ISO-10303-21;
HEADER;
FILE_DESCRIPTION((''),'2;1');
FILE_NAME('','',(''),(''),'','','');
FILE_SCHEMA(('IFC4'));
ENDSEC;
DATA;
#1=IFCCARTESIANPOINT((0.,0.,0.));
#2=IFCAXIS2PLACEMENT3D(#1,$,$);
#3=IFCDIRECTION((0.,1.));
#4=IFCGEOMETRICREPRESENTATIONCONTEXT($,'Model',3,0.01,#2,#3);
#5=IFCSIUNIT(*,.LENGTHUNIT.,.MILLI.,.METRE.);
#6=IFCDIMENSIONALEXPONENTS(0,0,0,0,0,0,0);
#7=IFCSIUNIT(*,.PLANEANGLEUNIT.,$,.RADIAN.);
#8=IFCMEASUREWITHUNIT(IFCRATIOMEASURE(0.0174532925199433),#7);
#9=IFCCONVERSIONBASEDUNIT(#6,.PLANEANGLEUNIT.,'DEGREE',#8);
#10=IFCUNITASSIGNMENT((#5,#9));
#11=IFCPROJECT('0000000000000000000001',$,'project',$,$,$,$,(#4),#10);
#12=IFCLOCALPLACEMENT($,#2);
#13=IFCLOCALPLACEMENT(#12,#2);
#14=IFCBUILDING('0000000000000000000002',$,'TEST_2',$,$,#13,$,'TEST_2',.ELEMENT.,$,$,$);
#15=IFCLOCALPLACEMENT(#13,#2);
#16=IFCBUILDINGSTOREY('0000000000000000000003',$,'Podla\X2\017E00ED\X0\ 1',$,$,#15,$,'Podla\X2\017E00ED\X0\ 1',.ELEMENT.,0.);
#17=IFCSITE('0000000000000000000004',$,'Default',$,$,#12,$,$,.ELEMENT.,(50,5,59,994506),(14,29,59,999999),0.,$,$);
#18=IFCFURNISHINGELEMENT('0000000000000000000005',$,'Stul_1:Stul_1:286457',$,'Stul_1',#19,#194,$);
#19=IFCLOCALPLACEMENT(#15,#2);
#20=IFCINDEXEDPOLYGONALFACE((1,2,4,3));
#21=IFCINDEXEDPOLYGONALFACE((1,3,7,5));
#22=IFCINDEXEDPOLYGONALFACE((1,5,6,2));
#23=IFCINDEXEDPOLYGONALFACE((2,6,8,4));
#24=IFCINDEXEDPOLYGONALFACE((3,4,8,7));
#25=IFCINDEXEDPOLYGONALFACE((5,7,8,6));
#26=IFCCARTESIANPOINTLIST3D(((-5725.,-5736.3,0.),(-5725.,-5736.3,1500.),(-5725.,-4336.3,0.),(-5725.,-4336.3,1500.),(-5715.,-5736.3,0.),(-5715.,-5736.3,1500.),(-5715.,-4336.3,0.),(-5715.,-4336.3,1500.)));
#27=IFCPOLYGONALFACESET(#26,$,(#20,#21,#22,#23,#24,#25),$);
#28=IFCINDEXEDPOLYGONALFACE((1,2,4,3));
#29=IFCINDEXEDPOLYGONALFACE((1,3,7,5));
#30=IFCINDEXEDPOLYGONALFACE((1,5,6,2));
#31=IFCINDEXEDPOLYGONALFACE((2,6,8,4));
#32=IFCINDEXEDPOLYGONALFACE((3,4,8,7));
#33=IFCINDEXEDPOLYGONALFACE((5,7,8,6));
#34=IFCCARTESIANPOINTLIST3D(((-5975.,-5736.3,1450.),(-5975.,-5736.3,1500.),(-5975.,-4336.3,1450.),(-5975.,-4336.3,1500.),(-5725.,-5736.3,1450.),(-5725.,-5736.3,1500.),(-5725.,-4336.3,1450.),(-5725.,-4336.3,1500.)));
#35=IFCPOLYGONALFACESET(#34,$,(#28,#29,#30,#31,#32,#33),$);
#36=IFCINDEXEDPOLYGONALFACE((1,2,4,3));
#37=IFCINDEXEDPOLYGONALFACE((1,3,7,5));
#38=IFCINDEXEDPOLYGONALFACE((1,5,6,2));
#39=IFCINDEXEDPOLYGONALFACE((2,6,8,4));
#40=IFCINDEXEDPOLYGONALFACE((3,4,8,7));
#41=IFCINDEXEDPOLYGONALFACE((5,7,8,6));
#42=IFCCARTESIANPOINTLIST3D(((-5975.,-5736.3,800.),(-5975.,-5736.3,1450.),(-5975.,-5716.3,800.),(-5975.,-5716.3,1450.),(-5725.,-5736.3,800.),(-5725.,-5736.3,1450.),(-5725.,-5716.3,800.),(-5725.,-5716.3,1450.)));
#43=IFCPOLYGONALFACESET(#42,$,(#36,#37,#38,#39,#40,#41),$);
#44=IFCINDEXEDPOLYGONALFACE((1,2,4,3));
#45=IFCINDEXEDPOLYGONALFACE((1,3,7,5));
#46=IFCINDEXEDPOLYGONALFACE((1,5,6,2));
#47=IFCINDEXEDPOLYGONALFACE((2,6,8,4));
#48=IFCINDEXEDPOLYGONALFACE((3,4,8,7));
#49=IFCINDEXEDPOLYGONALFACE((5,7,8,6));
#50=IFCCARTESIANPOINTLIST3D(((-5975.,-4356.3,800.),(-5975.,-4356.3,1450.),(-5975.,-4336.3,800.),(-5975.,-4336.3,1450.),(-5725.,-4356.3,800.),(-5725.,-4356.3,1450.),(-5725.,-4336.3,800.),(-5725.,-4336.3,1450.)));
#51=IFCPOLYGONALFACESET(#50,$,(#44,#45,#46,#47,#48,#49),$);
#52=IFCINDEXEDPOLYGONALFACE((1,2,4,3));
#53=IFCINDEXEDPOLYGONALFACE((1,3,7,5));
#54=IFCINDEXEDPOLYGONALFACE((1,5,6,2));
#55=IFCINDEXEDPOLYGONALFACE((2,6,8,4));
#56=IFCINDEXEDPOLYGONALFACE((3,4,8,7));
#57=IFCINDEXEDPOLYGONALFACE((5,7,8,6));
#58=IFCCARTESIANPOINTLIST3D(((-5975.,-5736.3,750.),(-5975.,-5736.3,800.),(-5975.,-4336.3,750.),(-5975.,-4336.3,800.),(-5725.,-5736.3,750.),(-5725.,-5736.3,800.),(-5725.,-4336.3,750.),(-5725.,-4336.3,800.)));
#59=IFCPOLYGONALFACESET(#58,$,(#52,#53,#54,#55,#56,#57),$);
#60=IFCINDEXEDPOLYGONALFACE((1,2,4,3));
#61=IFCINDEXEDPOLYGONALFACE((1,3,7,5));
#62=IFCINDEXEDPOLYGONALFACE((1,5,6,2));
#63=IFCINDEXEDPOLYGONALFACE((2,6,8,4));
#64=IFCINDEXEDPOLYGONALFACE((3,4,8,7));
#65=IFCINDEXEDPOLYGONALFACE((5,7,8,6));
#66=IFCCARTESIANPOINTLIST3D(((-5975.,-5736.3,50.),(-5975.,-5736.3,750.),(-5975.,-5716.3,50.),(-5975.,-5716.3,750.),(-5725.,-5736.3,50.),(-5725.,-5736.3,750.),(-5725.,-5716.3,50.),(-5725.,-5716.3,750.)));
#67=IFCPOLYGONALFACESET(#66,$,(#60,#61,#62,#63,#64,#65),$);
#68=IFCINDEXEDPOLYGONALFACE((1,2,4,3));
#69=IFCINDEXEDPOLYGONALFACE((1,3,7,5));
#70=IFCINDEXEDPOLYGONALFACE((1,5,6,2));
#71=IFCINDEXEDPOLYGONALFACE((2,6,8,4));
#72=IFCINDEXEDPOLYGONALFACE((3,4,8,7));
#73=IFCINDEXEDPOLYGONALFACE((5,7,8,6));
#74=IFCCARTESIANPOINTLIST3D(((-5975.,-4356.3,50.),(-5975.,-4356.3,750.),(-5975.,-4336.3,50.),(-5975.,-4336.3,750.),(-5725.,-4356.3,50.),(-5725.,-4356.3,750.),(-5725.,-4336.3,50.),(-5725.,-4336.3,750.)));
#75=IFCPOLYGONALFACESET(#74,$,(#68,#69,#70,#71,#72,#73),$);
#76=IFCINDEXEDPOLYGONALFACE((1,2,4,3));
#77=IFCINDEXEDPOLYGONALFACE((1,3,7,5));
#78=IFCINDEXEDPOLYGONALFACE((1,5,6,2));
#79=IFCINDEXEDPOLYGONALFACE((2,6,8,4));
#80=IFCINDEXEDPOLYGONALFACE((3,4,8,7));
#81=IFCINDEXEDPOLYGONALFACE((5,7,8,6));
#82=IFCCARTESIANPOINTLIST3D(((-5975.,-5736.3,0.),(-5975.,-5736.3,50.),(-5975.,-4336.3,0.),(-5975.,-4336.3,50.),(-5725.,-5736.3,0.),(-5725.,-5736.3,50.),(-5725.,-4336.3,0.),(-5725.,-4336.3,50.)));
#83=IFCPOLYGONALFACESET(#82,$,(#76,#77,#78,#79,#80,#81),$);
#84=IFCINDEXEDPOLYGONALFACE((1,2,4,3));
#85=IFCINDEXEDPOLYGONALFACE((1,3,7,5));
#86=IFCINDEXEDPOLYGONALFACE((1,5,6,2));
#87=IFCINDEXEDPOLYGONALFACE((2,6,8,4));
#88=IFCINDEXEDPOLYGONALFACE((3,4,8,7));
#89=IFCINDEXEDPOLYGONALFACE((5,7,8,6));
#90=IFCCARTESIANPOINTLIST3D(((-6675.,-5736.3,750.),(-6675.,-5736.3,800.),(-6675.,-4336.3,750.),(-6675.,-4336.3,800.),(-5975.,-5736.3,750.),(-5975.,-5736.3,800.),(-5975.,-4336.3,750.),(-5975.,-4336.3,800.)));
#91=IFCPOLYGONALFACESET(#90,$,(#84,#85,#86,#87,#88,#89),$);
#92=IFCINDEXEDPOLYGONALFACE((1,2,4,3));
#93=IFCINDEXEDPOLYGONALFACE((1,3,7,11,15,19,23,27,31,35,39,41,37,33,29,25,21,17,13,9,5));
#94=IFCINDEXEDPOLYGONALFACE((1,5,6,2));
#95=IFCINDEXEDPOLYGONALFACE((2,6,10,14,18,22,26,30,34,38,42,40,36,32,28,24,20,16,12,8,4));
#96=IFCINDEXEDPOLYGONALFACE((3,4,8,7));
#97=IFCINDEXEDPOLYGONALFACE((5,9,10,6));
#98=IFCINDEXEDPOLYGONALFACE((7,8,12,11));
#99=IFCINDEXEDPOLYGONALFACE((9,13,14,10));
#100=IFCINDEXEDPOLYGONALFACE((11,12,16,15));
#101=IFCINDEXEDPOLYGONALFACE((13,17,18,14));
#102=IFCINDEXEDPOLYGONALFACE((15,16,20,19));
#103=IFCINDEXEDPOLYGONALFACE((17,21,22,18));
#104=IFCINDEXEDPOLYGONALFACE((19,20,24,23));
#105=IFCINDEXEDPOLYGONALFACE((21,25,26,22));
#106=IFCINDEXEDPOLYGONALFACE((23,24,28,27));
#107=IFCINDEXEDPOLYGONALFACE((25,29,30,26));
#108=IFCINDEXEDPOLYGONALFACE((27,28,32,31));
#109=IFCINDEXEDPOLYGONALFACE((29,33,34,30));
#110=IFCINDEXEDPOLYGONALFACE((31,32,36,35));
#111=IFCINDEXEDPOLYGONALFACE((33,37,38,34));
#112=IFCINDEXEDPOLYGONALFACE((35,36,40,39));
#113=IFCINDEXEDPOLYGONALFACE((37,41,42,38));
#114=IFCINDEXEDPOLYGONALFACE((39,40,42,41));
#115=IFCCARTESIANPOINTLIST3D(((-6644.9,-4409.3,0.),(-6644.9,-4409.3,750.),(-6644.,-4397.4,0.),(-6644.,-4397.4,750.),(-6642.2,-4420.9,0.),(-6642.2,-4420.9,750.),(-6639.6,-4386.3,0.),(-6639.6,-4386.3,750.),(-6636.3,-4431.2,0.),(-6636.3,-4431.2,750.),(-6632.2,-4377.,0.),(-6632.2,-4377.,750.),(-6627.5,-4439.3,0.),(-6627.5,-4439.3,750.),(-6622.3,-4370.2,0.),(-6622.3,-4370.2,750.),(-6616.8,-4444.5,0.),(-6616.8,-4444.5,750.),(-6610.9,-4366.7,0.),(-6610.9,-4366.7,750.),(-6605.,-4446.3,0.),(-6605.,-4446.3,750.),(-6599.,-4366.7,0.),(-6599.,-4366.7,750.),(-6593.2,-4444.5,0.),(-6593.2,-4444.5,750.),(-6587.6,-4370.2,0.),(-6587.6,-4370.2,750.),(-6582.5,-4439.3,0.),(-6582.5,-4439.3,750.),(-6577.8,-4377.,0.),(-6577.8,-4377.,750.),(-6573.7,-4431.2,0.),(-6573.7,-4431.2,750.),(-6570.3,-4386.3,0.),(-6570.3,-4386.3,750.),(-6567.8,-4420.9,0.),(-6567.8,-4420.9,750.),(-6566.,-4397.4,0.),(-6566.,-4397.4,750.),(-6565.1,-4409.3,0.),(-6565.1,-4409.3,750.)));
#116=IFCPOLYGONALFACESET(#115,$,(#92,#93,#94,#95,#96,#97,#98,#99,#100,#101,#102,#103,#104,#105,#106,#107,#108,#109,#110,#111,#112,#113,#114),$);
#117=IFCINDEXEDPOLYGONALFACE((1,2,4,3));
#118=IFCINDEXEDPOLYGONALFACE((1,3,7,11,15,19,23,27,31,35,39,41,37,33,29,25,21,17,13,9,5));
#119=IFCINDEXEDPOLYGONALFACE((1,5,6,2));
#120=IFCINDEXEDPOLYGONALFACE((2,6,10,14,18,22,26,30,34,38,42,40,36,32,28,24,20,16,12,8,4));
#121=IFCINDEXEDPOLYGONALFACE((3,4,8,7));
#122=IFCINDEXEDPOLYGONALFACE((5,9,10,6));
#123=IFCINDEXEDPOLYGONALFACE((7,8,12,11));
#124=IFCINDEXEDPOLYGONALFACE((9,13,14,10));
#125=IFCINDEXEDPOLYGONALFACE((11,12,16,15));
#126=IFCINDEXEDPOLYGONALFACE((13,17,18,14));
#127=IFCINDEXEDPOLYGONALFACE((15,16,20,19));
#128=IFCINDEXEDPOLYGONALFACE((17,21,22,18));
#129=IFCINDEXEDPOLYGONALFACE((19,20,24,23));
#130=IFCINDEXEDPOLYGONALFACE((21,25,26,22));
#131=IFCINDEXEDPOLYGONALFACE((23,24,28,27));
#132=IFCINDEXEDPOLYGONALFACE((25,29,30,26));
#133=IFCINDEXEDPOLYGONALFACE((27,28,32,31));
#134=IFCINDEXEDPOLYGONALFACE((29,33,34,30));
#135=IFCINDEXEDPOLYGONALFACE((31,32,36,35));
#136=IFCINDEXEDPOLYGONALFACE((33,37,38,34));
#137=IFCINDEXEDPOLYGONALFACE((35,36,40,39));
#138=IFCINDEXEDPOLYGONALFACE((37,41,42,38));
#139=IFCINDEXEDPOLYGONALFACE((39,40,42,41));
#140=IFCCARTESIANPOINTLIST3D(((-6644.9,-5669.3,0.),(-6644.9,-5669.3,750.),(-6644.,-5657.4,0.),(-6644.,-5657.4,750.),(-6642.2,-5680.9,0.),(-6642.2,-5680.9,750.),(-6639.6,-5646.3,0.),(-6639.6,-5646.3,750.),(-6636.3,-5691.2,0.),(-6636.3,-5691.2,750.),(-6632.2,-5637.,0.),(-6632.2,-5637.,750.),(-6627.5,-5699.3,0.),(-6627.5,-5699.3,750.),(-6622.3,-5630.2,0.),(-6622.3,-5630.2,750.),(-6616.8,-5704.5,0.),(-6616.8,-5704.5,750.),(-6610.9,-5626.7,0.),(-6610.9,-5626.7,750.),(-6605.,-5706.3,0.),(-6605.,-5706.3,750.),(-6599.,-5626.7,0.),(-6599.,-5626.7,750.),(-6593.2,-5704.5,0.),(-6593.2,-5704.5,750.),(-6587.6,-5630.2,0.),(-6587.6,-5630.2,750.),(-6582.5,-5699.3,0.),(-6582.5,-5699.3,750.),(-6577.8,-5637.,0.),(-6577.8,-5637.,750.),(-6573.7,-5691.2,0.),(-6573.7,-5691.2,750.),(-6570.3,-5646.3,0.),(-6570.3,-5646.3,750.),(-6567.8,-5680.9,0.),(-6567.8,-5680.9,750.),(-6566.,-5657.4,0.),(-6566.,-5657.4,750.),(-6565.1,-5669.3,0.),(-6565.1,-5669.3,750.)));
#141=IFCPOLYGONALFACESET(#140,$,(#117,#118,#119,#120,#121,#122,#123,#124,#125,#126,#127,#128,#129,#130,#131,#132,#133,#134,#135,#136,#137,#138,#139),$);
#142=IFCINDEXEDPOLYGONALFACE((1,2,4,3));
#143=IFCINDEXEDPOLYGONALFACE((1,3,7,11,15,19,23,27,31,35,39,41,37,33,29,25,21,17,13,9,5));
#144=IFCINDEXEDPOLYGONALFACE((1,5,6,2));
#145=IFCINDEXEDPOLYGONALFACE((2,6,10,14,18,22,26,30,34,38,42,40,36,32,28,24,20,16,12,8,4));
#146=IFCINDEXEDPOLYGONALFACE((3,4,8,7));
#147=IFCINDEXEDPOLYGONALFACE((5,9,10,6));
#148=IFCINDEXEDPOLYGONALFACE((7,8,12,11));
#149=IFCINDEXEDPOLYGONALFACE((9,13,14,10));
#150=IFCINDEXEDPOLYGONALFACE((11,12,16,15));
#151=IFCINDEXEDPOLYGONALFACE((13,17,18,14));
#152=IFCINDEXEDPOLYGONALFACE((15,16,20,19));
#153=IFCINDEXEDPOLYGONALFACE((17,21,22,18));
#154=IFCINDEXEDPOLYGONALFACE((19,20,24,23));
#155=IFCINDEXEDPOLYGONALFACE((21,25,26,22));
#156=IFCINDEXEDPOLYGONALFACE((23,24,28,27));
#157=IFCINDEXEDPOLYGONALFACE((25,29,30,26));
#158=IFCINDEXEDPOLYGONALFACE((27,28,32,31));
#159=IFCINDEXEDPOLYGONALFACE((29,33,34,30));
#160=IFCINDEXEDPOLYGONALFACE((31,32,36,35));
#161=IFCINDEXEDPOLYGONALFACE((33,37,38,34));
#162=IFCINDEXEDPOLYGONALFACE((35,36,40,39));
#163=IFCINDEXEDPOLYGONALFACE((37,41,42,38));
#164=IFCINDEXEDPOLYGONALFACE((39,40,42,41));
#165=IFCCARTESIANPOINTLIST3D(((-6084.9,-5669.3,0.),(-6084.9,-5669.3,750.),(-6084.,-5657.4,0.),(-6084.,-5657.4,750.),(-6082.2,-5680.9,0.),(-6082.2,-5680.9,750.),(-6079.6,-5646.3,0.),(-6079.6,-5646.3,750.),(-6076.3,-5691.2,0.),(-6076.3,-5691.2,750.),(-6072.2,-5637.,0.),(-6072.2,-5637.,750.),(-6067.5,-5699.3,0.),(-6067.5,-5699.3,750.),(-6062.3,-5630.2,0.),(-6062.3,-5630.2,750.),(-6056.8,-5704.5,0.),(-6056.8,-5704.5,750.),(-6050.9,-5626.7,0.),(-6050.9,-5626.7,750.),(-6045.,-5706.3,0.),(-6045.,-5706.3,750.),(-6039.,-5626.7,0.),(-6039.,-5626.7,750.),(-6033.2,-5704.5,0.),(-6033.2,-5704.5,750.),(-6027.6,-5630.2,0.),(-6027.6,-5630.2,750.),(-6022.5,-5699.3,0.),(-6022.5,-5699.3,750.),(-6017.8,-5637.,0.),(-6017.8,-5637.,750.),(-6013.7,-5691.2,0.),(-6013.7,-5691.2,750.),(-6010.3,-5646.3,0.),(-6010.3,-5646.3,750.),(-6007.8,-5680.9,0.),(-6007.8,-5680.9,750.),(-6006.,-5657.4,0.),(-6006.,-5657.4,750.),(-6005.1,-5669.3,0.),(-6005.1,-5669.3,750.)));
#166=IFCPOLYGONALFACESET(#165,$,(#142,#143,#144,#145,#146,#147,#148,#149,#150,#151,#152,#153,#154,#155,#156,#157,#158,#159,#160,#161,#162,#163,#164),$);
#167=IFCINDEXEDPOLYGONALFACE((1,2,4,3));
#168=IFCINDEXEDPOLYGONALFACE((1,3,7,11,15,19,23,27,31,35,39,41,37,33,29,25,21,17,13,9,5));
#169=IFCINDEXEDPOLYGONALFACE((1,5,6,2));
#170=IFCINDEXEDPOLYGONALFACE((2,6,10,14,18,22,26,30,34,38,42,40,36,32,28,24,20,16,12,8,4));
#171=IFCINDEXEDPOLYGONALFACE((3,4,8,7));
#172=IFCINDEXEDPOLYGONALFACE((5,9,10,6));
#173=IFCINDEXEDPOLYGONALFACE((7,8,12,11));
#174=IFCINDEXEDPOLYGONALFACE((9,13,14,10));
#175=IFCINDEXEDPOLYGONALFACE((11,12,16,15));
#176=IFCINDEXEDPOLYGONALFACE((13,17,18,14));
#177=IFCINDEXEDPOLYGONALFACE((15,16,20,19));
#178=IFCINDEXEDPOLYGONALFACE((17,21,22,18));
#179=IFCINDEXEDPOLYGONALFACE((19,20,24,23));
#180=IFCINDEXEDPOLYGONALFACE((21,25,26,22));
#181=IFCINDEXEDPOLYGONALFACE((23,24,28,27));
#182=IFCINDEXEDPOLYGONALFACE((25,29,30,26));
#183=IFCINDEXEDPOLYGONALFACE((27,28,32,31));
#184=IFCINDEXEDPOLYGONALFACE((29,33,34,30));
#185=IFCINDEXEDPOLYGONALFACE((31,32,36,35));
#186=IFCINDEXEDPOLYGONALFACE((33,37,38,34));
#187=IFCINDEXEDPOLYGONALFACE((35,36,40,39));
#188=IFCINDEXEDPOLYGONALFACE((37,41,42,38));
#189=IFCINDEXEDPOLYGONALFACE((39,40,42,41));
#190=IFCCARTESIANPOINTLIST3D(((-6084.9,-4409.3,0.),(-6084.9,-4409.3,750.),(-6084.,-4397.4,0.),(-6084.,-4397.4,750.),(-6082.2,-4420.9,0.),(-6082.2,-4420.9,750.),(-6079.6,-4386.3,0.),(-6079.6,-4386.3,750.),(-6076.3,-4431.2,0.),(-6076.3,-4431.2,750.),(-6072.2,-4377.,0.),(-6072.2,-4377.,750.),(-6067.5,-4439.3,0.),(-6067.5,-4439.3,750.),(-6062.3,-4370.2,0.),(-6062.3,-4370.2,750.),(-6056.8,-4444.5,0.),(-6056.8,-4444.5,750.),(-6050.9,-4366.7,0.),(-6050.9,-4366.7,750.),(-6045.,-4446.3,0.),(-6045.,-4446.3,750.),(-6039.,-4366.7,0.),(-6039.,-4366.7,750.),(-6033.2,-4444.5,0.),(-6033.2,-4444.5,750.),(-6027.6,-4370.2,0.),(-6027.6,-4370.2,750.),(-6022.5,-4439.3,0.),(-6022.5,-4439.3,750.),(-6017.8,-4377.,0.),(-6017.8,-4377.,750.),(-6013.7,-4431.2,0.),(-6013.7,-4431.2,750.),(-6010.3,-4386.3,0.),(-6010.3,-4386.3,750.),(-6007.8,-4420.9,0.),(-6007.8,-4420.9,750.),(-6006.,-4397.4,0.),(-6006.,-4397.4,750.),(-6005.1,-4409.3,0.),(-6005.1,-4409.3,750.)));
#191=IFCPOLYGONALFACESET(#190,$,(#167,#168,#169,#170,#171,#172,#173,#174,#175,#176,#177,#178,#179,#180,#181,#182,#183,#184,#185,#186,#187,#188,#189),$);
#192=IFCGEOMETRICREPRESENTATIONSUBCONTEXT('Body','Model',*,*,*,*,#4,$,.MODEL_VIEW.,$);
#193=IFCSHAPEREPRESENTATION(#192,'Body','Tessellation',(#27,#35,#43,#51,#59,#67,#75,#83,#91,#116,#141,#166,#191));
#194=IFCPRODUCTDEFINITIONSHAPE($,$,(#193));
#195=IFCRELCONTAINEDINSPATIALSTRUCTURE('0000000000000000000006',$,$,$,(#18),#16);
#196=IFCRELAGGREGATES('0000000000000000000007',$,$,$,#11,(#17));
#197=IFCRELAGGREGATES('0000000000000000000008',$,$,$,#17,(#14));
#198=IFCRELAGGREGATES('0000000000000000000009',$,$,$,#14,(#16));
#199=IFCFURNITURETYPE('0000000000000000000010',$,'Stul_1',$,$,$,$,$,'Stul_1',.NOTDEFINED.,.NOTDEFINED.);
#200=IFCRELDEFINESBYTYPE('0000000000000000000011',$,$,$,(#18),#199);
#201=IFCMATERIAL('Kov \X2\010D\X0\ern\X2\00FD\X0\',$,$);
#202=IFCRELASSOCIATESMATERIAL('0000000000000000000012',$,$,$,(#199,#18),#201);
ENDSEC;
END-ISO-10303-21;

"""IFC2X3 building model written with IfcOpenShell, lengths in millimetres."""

from ifc_helpers import new_model, entity, si_unit, converted_unit, direction, frame, frame_2d, origin, origin_2d_with_axis, place, context, subcontext, project, spatial, rectangle, circle, extrude, source, transform, mapped, material, type_object, type_shapes, element, save


model = new_model("IFC2X3")

# Units and contexts
model_context = context("Model", 3, precision=0.01, world=origin(), true_north=direction((0.0, 1.0)))
body_context = subcontext(model_context, "Body", "Model", "MODEL_VIEW")
ifc_project = project(units=[si_unit("LENGTHUNIT", "METRE", prefix="MILLI"), converted_unit("PLANEANGLEUNIT", "DEGREE", entity("IfcRatioMeasure", 0.0174532925199433), si_unit("PLANEANGLEUNIT", "RADIAN"), dimensions=[0, 0, 0, 0, 0, 0, 0])], contexts=[model_context])

# Site, building, storey
site_placement = place(None, origin())
site = spatial("IfcSite", under=ifc_project, at=site_placement, Name="Default", CompositionType="ELEMENT", RefLatitude=(50, 5, 59, 994506), RefLongitude=(14, 29, 59, 999999), RefElevation=0.0)
building_placement = place(site_placement, origin())
building = spatial("IfcBuilding", under=site, at=building_placement, Name="TEST_2", LongName="TEST_2", CompositionType="ELEMENT")
storey_placement = place(building_placement, origin())
storey = spatial("IfcBuildingStorey", under=building, at=storey_placement, Name="Podlaží 1", LongName="Podlaží 1", CompositionType="ELEMENT", Elevation=0.0)

# Furnishing element
ifc_material = material(Name="Kov černý")
furniture_type = type_object("IfcFurnitureType", Name="Stul_1", ElementType="Stul_1", material=ifc_material)
shared_shape = source(origin(), body_context, "Body", "SweptSolid", [
    extrude(rectangle(XDim=1400.0, YDim=10.0, at=origin_2d_with_axis()), frame((0.0, 605.0, 0.0), z_axis=(0.0, 0.0, 1.0), x_axis=(-1.0, 0.0, 0.0)), (0.0, 0.0, 1.0), 1500.0),
    extrude(rectangle(XDim=1400.0, YDim=250.0, at=frame_2d((0.0, 0.0), x_axis=(1.0, 0.0))), frame((0.0, 475.0, 1450.0), z_axis=(0.0, 0.0, 1.0), x_axis=(-1.0, 0.0, 0.0)), (0.0, 0.0, 1.0), 50.0),
    extrude(rectangle(XDim=20.0, YDim=250.0, at=origin_2d_with_axis()), frame((690.0, 475.0, 800.0), z_axis=(0.0, 0.0, 1.0), x_axis=(-1.0, 0.0, 0.0)), (0.0, 0.0, 1.0), 650.0),
    extrude(rectangle(XDim=20.0, YDim=250.0, at=frame_2d((0.0, 0.0), x_axis=(1.0, 0.0))), frame((-690.0, 475.0, 800.0), z_axis=(0.0, 0.0, 1.0), x_axis=(-1.0, 0.0, 0.0)), (0.0, 0.0, 1.0), 650.0),
    extrude(rectangle(XDim=1400.0, YDim=250.0, at=origin_2d_with_axis()), frame((0.0, 475.0, 750.0), z_axis=(0.0, 0.0, 1.0), x_axis=(-1.0, 0.0, 0.0)), (0.0, 0.0, 1.0), 50.0),
    extrude(rectangle(XDim=20.0, YDim=250.0, at=origin_2d_with_axis()), frame((690.0, 475.0, 50.0), z_axis=(0.0, 0.0, 1.0), x_axis=(-1.0, 0.0, 0.0)), (0.0, 0.0, 1.0), 700.0),
    extrude(rectangle(XDim=20.0, YDim=250.0, at=frame_2d((0.0, 0.0), x_axis=(1.0, 0.0))), frame((-690.0, 475.0, 50.0), z_axis=(0.0, 0.0, 1.0), x_axis=(-1.0, 0.0, 0.0)), (0.0, 0.0, 1.0), 700.0),
    extrude(rectangle(XDim=1400.0, YDim=250.0, at=origin_2d_with_axis()), frame((0.0, 475.0, 0.0), z_axis=(0.0, 0.0, 1.0), x_axis=(-1.0, 0.0, 0.0)), (0.0, 0.0, 1.0), 50.0),
    extrude(rectangle(XDim=1400.0, YDim=700.0, at=origin_2d_with_axis()), frame((0.0, 0.0, 750.0), z_axis=(0.0, 0.0, 1.0), x_axis=(-1.0, 0.0, 0.0)), (0.0, 0.0, 1.0), 50.0),
    extrude(circle(Radius=40.0, at=frame_2d((0.0, 0.0), x_axis=(1.0, 0.0))), frame((-630.0, -280.0, 0.0)), (0.0, 0.0, 1.0), 750.0),
    extrude(circle(Radius=40.0, at=frame_2d((0.0, 0.0), x_axis=(1.0, 0.0))), frame((630.0, -280.0, 0.0)), (0.0, 0.0, 1.0), 750.0),
    extrude(circle(Radius=40.0, at=frame_2d((0.0, 0.0), x_axis=(1.0, 0.0))), frame((630.0, 280.0, 0.0)), (0.0, 0.0, 1.0), 750.0),
    extrude(circle(Radius=40.0, at=frame_2d((0.0, 0.0), x_axis=(1.0, 0.0))), frame((-630.0, 280.0, 0.0)), (0.0, 0.0, 1.0), 750.0),
])
type_shapes(furniture_type, [shared_shape])
for number, where, z_axis, x_axis, name in (
    (1, (-6325.0, -5036.3, 0.0), (0.0, 0.0, 1.0), (0.0, -1.0, 0.0), "Stul_1:Stul_1:286457"),
):
    element("IfcFurnishingElement", number, at=place(storey_placement, frame(where, z_axis=z_axis, x_axis=x_axis)), inside=storey, type_object=furniture_type, material=ifc_material, Name=name, ObjectType="Stul_1", context=body_context, shape_type="MappedRepresentation", body=[
        mapped(shared_shape, transform((0.0, 0.0, 0.0), scale=1.0)),
    ])

save(model, "model.ifc")
